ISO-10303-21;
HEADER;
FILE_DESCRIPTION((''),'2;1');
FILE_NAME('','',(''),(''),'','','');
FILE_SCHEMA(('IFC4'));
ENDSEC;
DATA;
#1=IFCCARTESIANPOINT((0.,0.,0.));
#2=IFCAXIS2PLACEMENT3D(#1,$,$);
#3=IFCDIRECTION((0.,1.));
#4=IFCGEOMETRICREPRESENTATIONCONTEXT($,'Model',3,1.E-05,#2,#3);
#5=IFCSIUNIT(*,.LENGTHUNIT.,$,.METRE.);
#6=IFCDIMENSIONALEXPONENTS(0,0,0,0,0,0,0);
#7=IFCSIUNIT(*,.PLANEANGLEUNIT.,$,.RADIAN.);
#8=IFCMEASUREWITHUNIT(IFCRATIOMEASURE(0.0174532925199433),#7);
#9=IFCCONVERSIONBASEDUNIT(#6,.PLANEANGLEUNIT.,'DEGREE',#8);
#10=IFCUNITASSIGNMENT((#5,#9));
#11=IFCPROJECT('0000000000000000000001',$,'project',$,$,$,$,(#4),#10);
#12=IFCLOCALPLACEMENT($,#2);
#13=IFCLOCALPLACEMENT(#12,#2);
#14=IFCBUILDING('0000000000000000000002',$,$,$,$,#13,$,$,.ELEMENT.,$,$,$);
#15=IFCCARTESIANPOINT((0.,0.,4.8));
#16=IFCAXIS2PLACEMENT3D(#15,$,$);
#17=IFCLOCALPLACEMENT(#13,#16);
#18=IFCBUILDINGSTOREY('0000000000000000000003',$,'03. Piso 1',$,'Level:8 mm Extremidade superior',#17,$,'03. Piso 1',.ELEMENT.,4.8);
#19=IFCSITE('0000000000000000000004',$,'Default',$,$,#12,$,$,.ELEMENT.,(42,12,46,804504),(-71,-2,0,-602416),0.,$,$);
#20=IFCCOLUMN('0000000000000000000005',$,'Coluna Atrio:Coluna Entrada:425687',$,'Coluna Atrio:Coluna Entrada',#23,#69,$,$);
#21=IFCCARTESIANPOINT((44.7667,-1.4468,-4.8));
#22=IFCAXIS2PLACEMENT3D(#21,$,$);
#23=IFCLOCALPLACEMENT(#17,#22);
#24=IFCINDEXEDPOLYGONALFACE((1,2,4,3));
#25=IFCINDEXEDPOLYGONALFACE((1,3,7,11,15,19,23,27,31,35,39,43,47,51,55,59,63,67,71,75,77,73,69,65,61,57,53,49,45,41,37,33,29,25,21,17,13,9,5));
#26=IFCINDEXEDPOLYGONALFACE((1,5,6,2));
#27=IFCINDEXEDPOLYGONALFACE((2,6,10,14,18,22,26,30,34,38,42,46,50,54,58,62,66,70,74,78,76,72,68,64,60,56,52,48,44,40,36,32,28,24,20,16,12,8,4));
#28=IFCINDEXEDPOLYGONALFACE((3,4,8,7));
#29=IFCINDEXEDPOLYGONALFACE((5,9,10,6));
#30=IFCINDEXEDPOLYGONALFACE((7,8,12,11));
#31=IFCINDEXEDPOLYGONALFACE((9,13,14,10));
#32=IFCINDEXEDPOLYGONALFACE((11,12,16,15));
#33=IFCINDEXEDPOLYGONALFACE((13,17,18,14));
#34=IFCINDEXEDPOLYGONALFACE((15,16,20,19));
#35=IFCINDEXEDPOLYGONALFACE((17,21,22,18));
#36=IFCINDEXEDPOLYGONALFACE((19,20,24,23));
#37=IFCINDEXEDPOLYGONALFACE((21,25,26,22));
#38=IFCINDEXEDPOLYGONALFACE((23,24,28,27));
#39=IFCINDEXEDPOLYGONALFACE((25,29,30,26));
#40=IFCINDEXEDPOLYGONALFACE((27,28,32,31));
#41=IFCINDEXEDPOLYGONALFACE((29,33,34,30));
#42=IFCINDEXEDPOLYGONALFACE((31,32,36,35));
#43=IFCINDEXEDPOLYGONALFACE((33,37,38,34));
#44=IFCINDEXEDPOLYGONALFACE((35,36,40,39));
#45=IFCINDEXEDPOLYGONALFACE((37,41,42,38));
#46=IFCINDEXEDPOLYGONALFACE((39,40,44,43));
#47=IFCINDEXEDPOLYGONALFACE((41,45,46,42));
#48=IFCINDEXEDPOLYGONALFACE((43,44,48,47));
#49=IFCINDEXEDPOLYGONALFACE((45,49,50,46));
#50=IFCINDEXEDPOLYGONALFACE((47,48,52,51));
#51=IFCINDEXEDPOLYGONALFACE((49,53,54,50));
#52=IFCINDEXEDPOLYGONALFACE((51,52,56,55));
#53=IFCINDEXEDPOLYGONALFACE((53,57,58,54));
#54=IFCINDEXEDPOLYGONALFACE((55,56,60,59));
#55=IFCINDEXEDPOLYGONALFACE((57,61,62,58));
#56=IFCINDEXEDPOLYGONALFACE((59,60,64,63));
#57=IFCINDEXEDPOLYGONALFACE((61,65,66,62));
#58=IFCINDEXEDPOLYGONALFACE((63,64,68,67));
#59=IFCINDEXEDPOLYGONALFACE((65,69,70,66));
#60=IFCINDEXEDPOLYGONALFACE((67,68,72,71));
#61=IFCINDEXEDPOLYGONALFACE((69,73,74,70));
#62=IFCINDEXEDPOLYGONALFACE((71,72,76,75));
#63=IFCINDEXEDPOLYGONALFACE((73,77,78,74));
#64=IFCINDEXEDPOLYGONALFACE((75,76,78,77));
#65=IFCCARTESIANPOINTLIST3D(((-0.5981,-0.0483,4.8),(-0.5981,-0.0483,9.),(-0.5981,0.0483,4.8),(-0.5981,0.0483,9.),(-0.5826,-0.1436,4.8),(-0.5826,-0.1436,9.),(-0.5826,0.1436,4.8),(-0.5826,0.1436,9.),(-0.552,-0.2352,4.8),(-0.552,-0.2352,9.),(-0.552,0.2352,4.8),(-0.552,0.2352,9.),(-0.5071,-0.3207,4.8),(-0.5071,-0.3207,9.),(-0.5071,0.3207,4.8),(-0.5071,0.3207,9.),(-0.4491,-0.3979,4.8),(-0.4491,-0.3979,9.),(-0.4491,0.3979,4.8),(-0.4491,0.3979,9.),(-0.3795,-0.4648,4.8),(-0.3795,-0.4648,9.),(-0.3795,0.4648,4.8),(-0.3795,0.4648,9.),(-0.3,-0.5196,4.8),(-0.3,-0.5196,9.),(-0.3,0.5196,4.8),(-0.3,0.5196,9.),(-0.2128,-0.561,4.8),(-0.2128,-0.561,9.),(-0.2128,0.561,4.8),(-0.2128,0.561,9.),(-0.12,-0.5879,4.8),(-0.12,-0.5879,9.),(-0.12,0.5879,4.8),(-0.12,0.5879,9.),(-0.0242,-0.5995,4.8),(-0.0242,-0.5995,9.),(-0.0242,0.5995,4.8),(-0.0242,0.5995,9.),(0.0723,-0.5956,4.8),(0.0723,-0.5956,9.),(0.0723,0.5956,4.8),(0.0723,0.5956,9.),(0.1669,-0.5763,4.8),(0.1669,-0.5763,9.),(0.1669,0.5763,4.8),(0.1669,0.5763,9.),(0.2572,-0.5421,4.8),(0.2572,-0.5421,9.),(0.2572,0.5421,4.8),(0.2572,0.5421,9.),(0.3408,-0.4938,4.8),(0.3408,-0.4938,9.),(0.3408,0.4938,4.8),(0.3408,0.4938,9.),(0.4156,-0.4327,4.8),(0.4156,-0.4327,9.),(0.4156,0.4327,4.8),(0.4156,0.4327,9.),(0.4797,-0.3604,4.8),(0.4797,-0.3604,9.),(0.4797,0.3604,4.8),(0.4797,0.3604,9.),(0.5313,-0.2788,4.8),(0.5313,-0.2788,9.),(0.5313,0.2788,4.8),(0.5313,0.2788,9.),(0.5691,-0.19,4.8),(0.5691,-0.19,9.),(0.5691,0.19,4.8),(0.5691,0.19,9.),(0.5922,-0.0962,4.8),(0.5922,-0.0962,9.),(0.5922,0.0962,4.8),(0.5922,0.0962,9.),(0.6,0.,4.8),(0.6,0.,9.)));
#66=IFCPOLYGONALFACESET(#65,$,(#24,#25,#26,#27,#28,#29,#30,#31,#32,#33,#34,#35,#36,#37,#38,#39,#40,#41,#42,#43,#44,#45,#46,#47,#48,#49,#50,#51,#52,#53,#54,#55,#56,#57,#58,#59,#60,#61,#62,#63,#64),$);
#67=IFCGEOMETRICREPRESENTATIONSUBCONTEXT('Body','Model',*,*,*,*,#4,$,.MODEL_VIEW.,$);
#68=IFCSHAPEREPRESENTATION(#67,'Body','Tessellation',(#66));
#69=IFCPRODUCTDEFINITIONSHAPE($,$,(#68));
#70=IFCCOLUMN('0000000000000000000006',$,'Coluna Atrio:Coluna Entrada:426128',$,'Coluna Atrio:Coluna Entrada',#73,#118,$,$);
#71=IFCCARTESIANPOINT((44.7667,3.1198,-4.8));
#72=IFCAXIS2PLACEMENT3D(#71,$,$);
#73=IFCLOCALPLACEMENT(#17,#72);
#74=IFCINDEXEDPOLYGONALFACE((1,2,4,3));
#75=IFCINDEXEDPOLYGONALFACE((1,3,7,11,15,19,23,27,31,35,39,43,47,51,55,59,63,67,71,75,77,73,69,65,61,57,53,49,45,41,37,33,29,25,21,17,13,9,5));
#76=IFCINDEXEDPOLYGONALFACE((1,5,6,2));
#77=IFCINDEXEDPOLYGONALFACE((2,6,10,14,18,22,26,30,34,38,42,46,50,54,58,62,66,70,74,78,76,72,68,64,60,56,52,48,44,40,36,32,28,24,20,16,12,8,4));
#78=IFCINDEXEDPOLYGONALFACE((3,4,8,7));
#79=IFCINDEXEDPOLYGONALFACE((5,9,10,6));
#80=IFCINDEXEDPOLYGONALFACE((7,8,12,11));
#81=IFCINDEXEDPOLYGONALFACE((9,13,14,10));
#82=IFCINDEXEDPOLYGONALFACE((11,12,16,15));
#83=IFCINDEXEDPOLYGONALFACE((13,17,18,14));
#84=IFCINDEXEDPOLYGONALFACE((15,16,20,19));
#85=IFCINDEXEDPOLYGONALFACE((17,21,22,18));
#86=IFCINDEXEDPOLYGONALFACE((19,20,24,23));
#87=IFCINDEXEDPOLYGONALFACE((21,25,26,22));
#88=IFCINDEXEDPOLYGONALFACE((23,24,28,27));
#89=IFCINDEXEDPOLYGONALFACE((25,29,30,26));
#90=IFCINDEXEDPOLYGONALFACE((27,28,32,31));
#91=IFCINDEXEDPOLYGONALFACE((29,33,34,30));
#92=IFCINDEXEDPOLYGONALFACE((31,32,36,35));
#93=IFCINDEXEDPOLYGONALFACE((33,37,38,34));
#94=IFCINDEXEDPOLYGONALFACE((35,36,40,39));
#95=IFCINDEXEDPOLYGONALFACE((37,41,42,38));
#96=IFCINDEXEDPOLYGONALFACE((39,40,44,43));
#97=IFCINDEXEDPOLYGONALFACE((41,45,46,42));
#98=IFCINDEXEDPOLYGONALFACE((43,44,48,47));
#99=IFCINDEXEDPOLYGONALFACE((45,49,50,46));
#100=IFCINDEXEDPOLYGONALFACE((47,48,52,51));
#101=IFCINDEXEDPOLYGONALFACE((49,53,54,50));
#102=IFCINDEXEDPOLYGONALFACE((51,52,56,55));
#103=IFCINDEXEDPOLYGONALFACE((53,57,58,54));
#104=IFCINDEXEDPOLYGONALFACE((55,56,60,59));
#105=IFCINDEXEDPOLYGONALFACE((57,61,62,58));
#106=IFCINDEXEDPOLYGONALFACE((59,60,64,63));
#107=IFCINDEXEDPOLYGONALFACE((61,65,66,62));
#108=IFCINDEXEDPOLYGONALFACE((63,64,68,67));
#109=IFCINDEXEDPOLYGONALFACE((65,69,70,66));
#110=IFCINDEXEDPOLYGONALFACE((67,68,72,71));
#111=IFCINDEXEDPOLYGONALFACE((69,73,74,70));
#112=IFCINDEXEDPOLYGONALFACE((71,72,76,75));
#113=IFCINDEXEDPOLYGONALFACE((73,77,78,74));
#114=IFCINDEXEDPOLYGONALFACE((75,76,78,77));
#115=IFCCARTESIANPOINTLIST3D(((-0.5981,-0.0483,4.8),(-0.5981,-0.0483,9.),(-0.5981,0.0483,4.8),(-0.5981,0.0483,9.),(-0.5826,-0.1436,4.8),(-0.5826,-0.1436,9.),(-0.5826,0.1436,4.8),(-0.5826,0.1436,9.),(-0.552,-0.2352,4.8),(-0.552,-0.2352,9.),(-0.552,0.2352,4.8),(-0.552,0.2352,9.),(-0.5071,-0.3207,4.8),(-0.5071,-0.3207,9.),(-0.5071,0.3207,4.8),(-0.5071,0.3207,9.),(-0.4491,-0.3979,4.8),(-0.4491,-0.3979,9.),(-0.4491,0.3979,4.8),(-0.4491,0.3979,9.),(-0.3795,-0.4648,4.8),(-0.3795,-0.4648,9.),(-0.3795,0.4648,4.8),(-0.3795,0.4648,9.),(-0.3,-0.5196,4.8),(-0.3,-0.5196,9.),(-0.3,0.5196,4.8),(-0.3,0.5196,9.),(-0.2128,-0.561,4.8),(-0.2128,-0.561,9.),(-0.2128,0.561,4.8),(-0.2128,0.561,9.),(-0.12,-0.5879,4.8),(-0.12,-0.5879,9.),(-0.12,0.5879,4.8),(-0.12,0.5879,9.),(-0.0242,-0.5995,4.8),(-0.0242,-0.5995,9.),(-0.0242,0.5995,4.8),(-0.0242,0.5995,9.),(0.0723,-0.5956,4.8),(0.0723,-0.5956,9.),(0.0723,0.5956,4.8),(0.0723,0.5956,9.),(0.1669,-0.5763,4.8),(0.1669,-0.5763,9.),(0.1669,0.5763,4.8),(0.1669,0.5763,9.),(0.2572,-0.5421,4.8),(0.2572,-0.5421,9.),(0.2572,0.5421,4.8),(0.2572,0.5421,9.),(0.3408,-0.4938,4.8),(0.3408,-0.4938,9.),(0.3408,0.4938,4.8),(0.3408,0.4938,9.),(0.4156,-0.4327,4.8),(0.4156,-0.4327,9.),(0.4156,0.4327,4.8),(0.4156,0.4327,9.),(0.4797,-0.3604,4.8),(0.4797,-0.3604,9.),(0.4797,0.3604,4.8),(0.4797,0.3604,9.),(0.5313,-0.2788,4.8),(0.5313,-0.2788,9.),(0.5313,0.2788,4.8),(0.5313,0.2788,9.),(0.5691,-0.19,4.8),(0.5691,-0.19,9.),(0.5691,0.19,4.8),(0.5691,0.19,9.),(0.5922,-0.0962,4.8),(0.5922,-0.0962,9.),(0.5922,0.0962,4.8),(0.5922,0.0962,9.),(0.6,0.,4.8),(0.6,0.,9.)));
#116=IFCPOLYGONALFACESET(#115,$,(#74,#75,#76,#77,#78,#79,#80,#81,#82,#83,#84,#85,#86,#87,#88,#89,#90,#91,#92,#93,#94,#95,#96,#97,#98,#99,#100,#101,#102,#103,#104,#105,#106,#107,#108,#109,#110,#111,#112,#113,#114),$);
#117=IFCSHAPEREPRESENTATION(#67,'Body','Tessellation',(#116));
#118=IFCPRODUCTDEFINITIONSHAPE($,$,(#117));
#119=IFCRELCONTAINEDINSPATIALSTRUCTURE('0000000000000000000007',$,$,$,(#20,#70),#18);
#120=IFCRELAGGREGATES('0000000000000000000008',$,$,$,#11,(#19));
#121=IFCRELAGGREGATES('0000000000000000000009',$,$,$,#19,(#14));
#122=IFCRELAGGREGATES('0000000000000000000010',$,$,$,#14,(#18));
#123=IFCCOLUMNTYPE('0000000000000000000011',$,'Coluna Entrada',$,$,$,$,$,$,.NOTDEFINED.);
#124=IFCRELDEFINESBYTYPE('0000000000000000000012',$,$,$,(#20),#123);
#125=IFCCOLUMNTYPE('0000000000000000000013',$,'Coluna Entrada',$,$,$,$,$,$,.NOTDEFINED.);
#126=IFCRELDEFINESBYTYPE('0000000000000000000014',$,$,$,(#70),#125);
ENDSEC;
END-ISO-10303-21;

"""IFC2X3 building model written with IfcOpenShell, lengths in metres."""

from ifc_helpers import new_model, entity, si_unit, converted_unit, direction, frame, frame_2d, origin, place, context, subcontext, project, spatial, circle, extrude, source, transform, mapped, type_object, type_shapes, element, save


model = new_model("IFC2X3")

# Units and contexts
model_context = context("Model", 3, precision=1e-05, world=origin(), true_north=direction((0.0, 1.0)))
body_context = subcontext(model_context, "Body", "Model", "MODEL_VIEW")
ifc_project = project(units=[si_unit("LENGTHUNIT", "METRE"), converted_unit("PLANEANGLEUNIT", "DEGREE", entity("IfcRatioMeasure", 0.0174532925199433), si_unit("PLANEANGLEUNIT", "RADIAN"), dimensions=[0, 0, 0, 0, 0, 0, 0])], contexts=[model_context])

# Site, building, storey
site_placement = place(None, origin())
site = spatial("IfcSite", under=ifc_project, at=site_placement, Name="Default", CompositionType="ELEMENT", RefLatitude=(42, 12, 46, 804504), RefLongitude=(-71, -2, 0, -602416), RefElevation=0.0)
building_placement = place(site_placement, origin())
building = spatial("IfcBuilding", under=site, at=building_placement, CompositionType="ELEMENT")
storey_placement = place(building_placement, frame((0.0, 0.0, 4.8)))
storey = spatial("IfcBuildingStorey", under=building, at=storey_placement, Name="03. Piso 1", ObjectType="Level:8 mm Extremidade superior", LongName="03. Piso 1", CompositionType="ELEMENT", Elevation=4.8)

# Columns
column_type_1 = type_object("IfcColumnType", Name="Coluna Entrada", PredefinedType="NOTDEFINED")
shared_shape_1 = source(origin(), body_context, "Body", "SweptSolid", [
    extrude(circle(Radius=0.6, at=frame_2d((0.0, 0.0), x_axis=(1.0, 0.0))), frame((0.0, 0.0, 4.8)), (0.0, 0.0, 1.0), 4.2),
])
type_shapes(column_type_1, [shared_shape_1])
column_1_placement = place(storey_placement, frame((44.7667, -1.4468, -4.8)))
element("IfcColumn", 1, at=column_1_placement, inside=storey, type_object=column_type_1, Name="Coluna Atrio:Coluna Entrada:425687", ObjectType="Coluna Atrio:Coluna Entrada", context=body_context, shape_type="MappedRepresentation", body=[
    mapped(shared_shape_1, transform((0.0, 0.0, 0.0), scale=1.0)),
])
column_type_2 = type_object("IfcColumnType", Name="Coluna Entrada", PredefinedType="NOTDEFINED")
shared_shape_2 = source(origin(), body_context, "Body", "SweptSolid", [
    extrude(circle(Radius=0.6, at=frame_2d((0.0, 0.0), x_axis=(1.0, 0.0))), frame((0.0, 0.0, 4.8)), (0.0, 0.0, 1.0), 4.2),
])
type_shapes(column_type_2, [shared_shape_2])
column_2_placement = place(storey_placement, frame((44.7667, 3.1198, -4.8)))
element("IfcColumn", 2, at=column_2_placement, inside=storey, type_object=column_type_2, Name="Coluna Atrio:Coluna Entrada:426128", ObjectType="Coluna Atrio:Coluna Entrada", context=body_context, shape_type="MappedRepresentation", body=[
    mapped(shared_shape_2, transform((0.0, 0.0, 0.0), scale=1.0)),
])

save(model, "model.ifc")
